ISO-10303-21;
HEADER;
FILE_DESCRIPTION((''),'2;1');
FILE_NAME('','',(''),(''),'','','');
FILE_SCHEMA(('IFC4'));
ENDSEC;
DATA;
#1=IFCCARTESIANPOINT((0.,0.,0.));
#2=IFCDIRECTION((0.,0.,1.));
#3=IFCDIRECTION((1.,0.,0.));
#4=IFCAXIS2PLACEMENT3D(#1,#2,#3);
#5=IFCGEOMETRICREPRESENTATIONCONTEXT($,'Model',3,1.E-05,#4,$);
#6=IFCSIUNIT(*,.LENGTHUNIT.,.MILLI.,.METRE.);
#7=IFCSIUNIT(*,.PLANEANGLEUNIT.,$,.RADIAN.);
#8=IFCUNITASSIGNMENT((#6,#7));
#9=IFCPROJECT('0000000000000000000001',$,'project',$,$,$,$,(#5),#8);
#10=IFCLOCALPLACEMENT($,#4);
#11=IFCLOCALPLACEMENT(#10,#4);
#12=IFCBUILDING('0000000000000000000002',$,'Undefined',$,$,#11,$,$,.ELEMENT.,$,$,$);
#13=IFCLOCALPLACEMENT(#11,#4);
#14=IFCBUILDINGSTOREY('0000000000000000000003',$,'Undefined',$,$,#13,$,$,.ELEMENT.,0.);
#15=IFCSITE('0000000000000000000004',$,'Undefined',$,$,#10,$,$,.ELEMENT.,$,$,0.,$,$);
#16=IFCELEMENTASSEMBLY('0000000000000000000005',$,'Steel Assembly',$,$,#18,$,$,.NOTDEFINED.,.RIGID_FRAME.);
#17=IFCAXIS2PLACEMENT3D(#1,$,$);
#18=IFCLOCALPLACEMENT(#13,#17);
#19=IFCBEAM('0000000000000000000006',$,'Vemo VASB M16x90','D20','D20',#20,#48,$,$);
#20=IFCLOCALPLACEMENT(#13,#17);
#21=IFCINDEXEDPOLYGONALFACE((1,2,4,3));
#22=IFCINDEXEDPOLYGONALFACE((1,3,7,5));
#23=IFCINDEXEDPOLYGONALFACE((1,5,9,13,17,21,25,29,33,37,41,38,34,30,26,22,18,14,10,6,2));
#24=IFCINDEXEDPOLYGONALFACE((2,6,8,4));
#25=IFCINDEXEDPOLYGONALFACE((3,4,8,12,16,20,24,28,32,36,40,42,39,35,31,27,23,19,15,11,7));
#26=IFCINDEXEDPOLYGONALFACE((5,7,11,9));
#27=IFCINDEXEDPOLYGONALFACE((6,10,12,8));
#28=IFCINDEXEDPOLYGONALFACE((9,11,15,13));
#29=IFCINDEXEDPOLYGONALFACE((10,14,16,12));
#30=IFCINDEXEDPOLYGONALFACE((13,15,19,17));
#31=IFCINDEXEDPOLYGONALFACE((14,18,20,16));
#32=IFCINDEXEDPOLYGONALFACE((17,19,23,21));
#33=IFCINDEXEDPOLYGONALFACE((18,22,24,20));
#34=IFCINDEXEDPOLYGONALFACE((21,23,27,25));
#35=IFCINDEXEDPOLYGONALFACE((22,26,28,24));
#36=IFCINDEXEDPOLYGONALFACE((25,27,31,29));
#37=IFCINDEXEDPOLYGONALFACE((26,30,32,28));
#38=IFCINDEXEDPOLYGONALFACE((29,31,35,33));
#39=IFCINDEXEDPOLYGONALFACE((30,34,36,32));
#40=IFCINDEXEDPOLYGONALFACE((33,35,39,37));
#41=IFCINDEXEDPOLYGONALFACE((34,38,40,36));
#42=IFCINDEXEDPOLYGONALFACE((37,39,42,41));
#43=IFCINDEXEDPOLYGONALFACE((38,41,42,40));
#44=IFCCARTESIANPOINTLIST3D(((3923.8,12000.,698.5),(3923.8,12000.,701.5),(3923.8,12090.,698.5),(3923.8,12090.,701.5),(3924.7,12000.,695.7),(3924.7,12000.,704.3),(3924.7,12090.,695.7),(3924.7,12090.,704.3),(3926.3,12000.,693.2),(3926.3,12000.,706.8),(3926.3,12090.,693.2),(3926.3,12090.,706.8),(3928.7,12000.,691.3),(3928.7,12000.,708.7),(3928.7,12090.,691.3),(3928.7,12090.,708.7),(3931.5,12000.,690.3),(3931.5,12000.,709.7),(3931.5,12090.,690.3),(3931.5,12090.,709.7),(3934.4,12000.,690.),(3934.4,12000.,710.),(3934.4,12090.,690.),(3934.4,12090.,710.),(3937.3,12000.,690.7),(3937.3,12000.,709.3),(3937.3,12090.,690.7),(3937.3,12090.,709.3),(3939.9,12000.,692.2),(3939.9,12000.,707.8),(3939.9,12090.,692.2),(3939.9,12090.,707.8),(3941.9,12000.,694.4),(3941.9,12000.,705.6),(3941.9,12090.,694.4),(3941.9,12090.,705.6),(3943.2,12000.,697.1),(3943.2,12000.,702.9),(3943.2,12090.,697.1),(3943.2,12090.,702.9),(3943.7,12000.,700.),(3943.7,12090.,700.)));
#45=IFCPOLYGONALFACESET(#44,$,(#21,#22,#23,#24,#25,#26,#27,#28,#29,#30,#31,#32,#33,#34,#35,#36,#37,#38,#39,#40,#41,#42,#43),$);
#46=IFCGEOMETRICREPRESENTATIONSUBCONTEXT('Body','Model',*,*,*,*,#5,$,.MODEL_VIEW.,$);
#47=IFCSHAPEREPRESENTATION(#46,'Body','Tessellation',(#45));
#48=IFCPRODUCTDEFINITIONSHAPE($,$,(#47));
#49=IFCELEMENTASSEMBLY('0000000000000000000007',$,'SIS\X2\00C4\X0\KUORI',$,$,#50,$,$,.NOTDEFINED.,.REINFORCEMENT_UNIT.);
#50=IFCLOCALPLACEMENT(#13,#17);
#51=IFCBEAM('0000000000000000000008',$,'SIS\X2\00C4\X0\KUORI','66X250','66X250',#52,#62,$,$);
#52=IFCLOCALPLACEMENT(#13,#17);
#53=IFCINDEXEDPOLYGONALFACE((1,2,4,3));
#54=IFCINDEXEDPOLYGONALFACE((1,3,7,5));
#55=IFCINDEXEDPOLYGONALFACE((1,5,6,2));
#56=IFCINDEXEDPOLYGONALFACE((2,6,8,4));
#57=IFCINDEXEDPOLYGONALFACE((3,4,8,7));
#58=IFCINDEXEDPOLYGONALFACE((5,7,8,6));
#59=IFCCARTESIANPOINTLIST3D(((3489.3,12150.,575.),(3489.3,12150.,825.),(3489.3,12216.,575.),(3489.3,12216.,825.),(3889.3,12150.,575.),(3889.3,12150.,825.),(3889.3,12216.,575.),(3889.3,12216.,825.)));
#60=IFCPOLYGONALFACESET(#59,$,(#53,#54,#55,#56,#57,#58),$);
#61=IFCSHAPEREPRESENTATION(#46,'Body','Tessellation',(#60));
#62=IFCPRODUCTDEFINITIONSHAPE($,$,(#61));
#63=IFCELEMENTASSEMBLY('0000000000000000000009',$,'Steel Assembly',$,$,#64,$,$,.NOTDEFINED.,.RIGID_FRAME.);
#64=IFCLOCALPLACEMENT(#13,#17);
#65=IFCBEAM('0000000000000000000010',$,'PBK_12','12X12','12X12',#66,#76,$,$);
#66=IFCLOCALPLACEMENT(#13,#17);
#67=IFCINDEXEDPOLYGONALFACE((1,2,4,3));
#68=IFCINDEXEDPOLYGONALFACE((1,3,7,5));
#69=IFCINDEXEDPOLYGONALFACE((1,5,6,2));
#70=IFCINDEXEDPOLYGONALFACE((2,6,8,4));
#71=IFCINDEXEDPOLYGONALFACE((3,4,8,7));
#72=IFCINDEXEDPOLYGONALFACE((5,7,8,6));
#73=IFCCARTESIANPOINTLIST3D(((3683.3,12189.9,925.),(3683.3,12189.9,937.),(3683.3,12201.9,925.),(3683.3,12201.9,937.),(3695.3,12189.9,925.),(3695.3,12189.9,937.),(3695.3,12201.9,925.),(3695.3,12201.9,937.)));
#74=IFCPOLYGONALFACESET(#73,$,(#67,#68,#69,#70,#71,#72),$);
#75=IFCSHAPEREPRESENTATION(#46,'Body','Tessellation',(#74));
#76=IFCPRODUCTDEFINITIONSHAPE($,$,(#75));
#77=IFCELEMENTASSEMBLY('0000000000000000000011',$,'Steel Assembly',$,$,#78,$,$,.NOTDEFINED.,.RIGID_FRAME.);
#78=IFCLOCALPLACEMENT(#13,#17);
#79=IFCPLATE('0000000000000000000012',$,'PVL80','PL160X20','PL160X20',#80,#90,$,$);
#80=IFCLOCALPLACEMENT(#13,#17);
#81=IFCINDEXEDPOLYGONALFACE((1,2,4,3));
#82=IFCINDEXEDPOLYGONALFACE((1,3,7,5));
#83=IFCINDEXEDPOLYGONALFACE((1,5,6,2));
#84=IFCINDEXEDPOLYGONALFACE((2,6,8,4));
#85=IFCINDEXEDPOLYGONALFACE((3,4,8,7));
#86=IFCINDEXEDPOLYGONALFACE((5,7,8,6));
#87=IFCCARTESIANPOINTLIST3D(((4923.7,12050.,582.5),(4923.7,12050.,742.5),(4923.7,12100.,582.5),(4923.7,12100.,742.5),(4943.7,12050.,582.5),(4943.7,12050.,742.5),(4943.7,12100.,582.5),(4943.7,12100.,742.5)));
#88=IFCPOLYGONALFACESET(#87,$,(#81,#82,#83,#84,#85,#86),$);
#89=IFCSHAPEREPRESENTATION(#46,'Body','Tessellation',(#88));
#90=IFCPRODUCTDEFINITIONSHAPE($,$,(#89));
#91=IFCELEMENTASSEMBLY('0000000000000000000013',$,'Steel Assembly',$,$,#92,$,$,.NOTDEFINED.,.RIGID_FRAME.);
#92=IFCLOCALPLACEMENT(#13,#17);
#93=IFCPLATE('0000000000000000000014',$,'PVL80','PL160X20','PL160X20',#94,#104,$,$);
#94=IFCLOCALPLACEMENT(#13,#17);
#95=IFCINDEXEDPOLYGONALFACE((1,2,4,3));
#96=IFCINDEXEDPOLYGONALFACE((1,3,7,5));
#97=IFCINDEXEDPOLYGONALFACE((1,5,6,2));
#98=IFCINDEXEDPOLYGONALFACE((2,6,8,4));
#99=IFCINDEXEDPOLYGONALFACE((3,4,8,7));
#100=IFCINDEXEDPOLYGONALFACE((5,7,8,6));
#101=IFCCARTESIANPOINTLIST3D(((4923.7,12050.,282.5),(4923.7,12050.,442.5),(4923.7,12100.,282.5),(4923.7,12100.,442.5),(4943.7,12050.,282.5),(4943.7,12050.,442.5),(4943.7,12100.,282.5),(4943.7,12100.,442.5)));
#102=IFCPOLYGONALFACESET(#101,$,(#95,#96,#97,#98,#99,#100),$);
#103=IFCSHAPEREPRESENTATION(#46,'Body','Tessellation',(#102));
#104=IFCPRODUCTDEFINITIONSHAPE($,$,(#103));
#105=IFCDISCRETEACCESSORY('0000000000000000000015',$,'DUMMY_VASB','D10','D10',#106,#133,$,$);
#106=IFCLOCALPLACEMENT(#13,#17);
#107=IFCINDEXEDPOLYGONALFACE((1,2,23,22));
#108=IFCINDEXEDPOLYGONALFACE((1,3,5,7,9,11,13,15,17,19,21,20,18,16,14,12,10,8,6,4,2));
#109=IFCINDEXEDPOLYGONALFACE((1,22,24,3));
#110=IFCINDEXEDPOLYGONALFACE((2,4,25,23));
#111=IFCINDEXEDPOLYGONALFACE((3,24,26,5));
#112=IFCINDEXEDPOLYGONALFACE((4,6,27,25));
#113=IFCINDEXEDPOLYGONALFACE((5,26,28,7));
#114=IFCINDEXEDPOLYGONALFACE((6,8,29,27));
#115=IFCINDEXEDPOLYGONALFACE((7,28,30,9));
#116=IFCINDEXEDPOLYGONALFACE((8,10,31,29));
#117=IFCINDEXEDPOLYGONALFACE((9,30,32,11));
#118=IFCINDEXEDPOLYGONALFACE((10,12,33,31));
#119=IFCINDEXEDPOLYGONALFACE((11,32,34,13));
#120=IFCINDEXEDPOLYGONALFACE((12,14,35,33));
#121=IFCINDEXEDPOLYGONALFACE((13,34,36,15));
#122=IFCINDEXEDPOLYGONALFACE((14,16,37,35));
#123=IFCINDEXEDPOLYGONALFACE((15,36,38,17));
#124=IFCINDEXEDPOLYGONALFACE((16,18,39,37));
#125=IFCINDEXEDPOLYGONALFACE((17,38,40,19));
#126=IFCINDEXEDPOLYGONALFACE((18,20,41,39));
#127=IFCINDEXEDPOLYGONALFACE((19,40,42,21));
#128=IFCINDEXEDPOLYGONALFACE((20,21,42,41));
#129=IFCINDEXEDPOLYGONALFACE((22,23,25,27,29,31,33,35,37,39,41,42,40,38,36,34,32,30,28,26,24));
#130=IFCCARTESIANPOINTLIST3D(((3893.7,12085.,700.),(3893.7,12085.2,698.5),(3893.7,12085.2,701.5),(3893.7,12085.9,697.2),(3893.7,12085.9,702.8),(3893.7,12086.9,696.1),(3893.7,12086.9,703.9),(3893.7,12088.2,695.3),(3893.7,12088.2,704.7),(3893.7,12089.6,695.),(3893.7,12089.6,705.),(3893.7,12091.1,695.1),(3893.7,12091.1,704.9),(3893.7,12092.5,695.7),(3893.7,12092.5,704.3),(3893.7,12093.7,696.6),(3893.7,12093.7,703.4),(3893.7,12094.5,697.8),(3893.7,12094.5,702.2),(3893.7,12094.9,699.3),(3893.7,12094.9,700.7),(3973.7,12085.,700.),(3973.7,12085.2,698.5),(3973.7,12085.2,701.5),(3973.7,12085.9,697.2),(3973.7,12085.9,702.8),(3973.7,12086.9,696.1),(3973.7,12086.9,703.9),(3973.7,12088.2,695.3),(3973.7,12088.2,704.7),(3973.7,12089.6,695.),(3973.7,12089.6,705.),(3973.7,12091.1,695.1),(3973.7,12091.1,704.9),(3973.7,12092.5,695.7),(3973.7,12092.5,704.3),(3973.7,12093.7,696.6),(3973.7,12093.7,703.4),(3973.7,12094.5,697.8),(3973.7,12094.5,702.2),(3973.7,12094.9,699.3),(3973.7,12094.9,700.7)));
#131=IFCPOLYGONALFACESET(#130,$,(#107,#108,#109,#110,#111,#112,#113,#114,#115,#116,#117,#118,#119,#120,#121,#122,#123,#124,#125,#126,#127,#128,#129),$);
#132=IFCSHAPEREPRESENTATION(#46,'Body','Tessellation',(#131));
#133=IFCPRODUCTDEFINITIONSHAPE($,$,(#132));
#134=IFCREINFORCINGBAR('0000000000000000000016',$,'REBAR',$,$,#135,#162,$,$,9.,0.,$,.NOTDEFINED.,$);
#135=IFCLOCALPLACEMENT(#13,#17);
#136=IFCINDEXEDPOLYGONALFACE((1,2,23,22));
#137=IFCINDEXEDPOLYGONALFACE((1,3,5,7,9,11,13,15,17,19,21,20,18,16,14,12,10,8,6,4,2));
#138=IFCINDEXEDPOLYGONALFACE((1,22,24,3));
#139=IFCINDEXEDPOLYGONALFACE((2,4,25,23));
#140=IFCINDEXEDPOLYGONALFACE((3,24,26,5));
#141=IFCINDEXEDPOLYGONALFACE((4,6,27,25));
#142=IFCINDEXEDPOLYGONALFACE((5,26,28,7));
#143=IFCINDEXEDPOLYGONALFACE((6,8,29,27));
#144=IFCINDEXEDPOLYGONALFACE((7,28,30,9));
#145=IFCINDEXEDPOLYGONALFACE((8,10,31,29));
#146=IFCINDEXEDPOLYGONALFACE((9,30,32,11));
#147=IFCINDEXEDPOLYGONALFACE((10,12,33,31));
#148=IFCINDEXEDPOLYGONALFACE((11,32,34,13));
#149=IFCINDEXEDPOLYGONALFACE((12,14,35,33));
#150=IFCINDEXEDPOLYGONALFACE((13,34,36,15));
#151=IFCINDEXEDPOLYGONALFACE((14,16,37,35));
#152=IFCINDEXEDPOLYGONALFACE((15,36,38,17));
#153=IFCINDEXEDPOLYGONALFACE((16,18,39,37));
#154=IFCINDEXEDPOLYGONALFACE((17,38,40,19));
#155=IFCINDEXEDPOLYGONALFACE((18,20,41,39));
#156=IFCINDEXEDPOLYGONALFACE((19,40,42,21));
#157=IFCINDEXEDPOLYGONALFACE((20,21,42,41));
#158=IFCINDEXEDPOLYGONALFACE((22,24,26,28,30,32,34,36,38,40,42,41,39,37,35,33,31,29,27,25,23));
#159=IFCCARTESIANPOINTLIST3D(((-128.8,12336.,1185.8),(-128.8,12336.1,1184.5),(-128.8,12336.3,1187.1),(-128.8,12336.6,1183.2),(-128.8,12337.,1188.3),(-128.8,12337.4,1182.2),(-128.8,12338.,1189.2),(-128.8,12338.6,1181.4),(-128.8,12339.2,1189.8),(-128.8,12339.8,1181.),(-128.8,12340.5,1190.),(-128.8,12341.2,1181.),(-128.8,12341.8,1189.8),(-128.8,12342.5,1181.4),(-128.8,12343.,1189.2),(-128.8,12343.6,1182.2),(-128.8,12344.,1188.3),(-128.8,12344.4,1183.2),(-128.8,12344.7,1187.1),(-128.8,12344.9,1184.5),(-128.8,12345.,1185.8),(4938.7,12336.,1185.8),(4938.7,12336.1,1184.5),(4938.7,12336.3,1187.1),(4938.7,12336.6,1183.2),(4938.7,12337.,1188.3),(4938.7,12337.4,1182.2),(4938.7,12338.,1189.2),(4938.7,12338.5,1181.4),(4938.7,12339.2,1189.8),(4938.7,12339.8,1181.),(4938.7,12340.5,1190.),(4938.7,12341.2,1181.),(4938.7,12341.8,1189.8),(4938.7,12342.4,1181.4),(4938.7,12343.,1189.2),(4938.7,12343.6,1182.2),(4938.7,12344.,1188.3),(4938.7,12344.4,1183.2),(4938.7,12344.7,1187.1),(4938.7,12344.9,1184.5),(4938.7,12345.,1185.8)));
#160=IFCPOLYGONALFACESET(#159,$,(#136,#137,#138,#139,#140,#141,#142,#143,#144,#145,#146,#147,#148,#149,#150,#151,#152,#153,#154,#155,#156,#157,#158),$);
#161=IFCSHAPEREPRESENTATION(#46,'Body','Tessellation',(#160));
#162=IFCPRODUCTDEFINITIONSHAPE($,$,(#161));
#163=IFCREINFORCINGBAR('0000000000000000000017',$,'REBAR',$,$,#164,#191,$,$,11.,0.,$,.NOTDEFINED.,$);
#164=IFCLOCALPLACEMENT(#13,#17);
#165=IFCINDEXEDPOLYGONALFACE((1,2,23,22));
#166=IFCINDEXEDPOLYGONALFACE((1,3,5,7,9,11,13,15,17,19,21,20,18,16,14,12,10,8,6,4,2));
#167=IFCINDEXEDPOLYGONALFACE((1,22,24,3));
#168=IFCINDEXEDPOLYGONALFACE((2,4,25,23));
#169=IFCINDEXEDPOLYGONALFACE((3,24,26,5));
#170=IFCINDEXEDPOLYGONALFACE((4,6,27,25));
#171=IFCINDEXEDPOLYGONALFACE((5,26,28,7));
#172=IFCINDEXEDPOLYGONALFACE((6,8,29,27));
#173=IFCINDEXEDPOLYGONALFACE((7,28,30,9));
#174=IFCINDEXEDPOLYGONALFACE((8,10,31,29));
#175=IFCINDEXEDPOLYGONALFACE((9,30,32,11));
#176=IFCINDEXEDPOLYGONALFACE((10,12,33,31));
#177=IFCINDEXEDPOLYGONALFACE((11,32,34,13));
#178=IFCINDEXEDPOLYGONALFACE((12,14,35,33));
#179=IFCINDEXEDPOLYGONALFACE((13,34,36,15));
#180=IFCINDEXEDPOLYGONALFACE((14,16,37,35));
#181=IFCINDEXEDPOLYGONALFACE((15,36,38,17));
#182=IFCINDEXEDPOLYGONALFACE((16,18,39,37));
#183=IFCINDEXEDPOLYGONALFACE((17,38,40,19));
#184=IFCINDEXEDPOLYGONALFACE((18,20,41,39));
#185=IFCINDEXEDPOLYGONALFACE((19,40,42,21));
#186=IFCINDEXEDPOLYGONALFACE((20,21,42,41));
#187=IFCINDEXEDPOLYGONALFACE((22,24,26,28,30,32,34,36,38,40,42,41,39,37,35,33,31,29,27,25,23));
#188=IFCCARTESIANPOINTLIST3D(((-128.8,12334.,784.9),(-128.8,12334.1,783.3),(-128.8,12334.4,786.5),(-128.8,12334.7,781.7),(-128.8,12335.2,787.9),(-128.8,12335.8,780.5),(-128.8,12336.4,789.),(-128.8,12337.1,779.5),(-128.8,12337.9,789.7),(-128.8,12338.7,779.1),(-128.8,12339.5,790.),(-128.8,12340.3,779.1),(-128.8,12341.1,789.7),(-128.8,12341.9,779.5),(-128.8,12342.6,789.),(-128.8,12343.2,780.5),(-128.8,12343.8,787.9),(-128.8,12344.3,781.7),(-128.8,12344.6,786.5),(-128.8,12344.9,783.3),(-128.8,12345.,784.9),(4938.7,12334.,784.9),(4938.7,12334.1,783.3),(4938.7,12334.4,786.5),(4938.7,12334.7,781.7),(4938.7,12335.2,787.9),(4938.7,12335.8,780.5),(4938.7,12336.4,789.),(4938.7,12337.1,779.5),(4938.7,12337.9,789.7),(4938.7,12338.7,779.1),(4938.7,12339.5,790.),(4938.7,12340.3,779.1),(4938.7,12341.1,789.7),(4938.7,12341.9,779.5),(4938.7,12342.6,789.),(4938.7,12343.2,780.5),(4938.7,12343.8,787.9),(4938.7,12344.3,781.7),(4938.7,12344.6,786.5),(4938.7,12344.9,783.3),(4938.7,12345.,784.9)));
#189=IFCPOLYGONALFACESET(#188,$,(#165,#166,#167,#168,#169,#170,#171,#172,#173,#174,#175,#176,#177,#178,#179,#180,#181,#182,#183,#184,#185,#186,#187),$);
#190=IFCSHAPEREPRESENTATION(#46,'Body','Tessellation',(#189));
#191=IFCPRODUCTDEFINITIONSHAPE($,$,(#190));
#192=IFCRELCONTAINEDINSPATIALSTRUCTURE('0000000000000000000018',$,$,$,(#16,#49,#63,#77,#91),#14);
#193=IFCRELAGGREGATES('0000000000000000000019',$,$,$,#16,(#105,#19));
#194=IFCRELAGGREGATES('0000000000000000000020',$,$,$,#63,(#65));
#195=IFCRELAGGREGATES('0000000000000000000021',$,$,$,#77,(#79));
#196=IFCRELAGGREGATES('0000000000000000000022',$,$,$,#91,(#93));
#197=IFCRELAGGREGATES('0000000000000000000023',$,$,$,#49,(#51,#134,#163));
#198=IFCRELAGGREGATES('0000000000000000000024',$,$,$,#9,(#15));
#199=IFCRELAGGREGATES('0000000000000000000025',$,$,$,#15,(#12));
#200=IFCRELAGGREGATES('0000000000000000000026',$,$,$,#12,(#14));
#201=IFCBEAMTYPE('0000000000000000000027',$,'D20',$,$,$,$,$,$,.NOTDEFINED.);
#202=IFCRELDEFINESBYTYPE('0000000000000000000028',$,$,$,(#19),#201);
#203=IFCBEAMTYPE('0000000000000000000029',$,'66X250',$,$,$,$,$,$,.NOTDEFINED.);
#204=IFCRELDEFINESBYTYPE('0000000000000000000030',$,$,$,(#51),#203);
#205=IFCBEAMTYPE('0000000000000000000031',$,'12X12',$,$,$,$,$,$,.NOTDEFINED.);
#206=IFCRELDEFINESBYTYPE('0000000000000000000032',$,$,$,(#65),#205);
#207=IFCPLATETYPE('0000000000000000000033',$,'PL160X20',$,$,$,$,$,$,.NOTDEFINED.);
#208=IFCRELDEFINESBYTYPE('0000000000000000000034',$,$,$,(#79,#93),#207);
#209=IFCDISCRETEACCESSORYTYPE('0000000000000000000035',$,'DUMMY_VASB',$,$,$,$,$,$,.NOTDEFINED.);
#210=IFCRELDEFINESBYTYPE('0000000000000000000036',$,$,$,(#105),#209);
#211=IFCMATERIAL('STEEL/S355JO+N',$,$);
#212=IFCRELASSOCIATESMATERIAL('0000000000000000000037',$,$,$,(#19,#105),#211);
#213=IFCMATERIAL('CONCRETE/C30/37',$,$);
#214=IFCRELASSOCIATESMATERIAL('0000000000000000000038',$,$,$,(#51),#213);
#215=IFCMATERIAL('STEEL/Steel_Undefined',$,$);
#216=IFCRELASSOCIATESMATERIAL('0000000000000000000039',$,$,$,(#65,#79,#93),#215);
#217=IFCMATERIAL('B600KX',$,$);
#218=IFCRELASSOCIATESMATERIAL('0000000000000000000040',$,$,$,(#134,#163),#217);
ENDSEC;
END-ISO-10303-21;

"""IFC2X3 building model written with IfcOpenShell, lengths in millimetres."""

from ifc_helpers import new_model, entity, si_unit, frame, origin_with_axes, origin_2d_with_axis, place, context, subcontext, project, spatial, polyline, rectangle, circle, outline, extrude, source, transform, mapped, material, type_object, element, aggregate, save


model = new_model("IFC2X3")

# Units and contexts
model_context = context("Model", 3, precision=1e-05, world=origin_with_axes())
body_context = subcontext(model_context, "Body", "Model", "MODEL_VIEW")
ifc_project = project(units=[si_unit("LENGTHUNIT", "METRE", prefix="MILLI"), si_unit("PLANEANGLEUNIT", "RADIAN")], contexts=[model_context])

# Site, building, storey
site_placement = place(None, origin_with_axes())
site = spatial("IfcSite", under=ifc_project, at=site_placement, Name="Undefined", CompositionType="ELEMENT", RefElevation=0.0)
building_placement = place(site_placement, origin_with_axes())
building = spatial("IfcBuilding", under=site, at=building_placement, Name="Undefined", CompositionType="ELEMENT")
storey_placement = place(building_placement, origin_with_axes())
storey = spatial("IfcBuildingStorey", under=building, at=storey_placement, Name="Undefined", CompositionType="ELEMENT", Elevation=0.0)

# Element assemblies, beams
assembly_1_placement = place(storey_placement, origin_with_axes())
assembly_1 = element("IfcElementAssembly", 1, at=assembly_1_placement, inside=storey, Name="Steel Assembly", AssemblyPlace="NOTDEFINED", PredefinedType="RIGID_FRAME")
ifc_material_1 = material(Name="STEEL/S355JO+N")
beam_type_1 = type_object("IfcBeamType", Name="D20", PredefinedType="NOTDEFINED")
beam_1_placement = place(assembly_1_placement, frame((3933.7, 12000.0, 700.0), z_axis=(0.0, 0.0, 1.0), x_axis=(0.0, 1.0, 0.0)))
beam_1 = element("IfcBeam", 2, at=beam_1_placement, type_object=beam_type_1, material=ifc_material_1, Name="Vemo VASB M16x90", Description="D20", ObjectType="D20", context=body_context, shape_type="SweptSolid", body=[
    extrude(circle(Radius=10.0, at=origin_2d_with_axis()), frame((90.0, 0.0, 0.0), z_axis=(-1.0, 0.0, 0.0), x_axis=(0.0, -1.0, 0.0)), (0.0, 0.0, 1.0), 90.0),
])
assembly_2_placement = place(storey_placement, origin_with_axes())
assembly_2 = element("IfcElementAssembly", 3, at=assembly_2_placement, inside=storey, Name="SISÄKUORI", AssemblyPlace="NOTDEFINED", PredefinedType="REINFORCEMENT_UNIT")
ifc_material_2 = material(Name="CONCRETE/C30/37")
beam_type_2 = type_object("IfcBeamType", Name="66X250", PredefinedType="NOTDEFINED")
beam_2_placement = place(assembly_2_placement, frame((3489.3, 12183.0, 700.0), z_axis=(0.0, -1.0, 0.0), x_axis=(1.0, 0.0, 0.0)))
beam_2 = element("IfcBeam", 4, at=beam_2_placement, type_object=beam_type_2, material=ifc_material_2, Name="SISÄKUORI", Description="66X250", ObjectType="66X250", context=body_context, shape_type="SweptSolid", body=[
    extrude(rectangle(XDim=250.0, YDim=66.0, at=origin_2d_with_axis()), frame((400.0, 0.0, 0.0), z_axis=(-1.0, 0.0, 0.0), x_axis=(0.0, -1.0, 0.0)), (0.0, 0.0, 1.0), 400.0),
])
assembly_3_placement = place(storey_placement, origin_with_axes())
assembly_3 = element("IfcElementAssembly", 5, at=assembly_3_placement, inside=storey, Name="Steel Assembly", AssemblyPlace="NOTDEFINED", PredefinedType="RIGID_FRAME")
ifc_material_3 = material(Name="STEEL/Steel_Undefined")
beam_type_3 = type_object("IfcBeamType", Name="12X12", PredefinedType="NOTDEFINED")
beam_3_placement = place(assembly_3_placement, frame((3695.3, 12195.9, 931.0), z_axis=(0.0, 0.0, 1.0), x_axis=(-1.0, 0.0, 0.0)))
beam_3 = element("IfcBeam", 6, at=beam_3_placement, type_object=beam_type_3, material=ifc_material_3, Name="PBK_12", Description="12X12", ObjectType="12X12", context=body_context, shape_type="SweptSolid", body=[
    extrude(rectangle(XDim=12.0, YDim=12.0, at=origin_2d_with_axis()), frame((12.0, 0.0, 0.0), z_axis=(-1.0, 0.0, 0.0), x_axis=(0.0, -1.0, 0.0)), (0.0, 0.0, 1.0), 12.0),
])

# Element assemblies, plates
assembly_4_placement = place(storey_placement, origin_with_axes())
assembly_4 = element("IfcElementAssembly", 7, at=assembly_4_placement, inside=storey, Name="Steel Assembly", AssemblyPlace="NOTDEFINED", PredefinedType="RIGID_FRAME")
plate_type = type_object("IfcPlateType", Name="PL160X20", PredefinedType="NOTDEFINED")
plate_1_placement = place(assembly_4_placement, frame((4943.7, 12100.0, 662.5), z_axis=(0.0, 0.0, -1.0), x_axis=(0.0, -1.0, 0.0)))
plate_1 = element("IfcPlate", 8, at=plate_1_placement, type_object=plate_type, material=ifc_material_3, Name="PVL80", Description="PL160X20", ObjectType="PL160X20", context=body_context, shape_type="SweptSolid", body=[
    extrude(outline(polyline([(0.0, 0.0), (50.0, 0.0), (50.0, 20.0), (0.0, 20.0), (0.0, 0.0)])), frame((0.0, 0.0, -80.0), z_axis=(0.0, 0.0, 1.0), x_axis=(1.0, 0.0, 0.0)), (0.0, 0.0, 1.0), 160.0),
])
assembly_5_placement = place(storey_placement, origin_with_axes())
assembly_5 = element("IfcElementAssembly", 9, at=assembly_5_placement, inside=storey, Name="Steel Assembly", AssemblyPlace="NOTDEFINED", PredefinedType="RIGID_FRAME")
plate_2_placement = place(assembly_5_placement, frame((4943.7, 12100.0, 362.5), z_axis=(0.0, 0.0, -1.0), x_axis=(0.0, -1.0, 0.0)))
plate_2 = element("IfcPlate", 10, at=plate_2_placement, type_object=plate_type, material=ifc_material_3, Name="PVL80", Description="PL160X20", ObjectType="PL160X20", context=body_context, shape_type="SweptSolid", body=[
    extrude(outline(polyline([(0.0, 0.0), (50.0, 0.0), (50.0, 20.0), (0.0, 20.0), (0.0, 0.0)])), frame((0.0, 0.0, -80.0), z_axis=(0.0, 0.0, 1.0), x_axis=(1.0, 0.0, 0.0)), (0.0, 0.0, 1.0), 160.0),
])

# Discrete accessory
discrete_accessory_type = type_object("IfcDiscreteAccessoryType", Name="DUMMY_VASB")
discrete_accessory_placement = place(assembly_1_placement, frame((3893.7, 12090.0, 700.0), z_axis=(0.0, 0.0, 1.0), x_axis=(1.0, 0.0, 0.0)))
discrete_accessory = element("IfcDiscreteAccessory", 11, at=discrete_accessory_placement, type_object=discrete_accessory_type, material=ifc_material_1, Name="DUMMY_VASB", Description="D10", ObjectType="D10", context=body_context, shape_type="SweptSolid", body=[
    extrude(circle(Radius=5.0, at=origin_2d_with_axis()), frame((80.0, 0.0, 0.0), z_axis=(-1.0, 0.0, 0.0), x_axis=(0.0, -1.0, 0.0)), (0.0, 0.0, 1.0), 80.0),
])
aggregate(assembly_1, [discrete_accessory, beam_1])

# Reinforcing bars
aggregate(assembly_3, [beam_3])
aggregate(assembly_4, [plate_1])
aggregate(assembly_5, [plate_2])
ifc_material_4 = material(Name="B600KX")
shared_shape_1 = source(origin_with_axes(), body_context, "Body", "AdvancedSweptSolid", [
    entity("IfcSweptDiskSolid", entity("IfcTrimmedCurve", entity("IfcLine", entity("IfcCartesianPoint", [0.0, 0.0, 0.0]), entity("IfcVector", entity("IfcDirection", [1.0, 0.0, 0.0]), 1.0)), [entity("IfcParameterValue", 0.0)], [entity("IfcParameterValue", 5067.479996)], True, "PARAMETER"), 4.5, None, 0.0, 5067.5),
])
reinforcing_bar_1_placement = place(assembly_2_placement, frame((4938.7, 12340.5, 1185.5), z_axis=(0.0, 0.0, 1.0), x_axis=(-1.0, 0.000003, 0.0)))
reinforcing_bar_1 = element("IfcReinforcingBar", 12, at=reinforcing_bar_1_placement, material=ifc_material_4, Name="REBAR", BarRole="NOTDEFINED", CrossSectionArea=0.0, NominalDiameter=9.0, context=body_context, shape_type="MappedRepresentation", body=[
    mapped(shared_shape_1, transform((0.0, 0.0, 0.0))),
])
shared_shape_2 = source(origin_with_axes(), body_context, "Body", "AdvancedSweptSolid", [
    entity("IfcSweptDiskSolid", entity("IfcTrimmedCurve", entity("IfcLine", entity("IfcCartesianPoint", [0.0, 0.0, 0.0]), entity("IfcVector", entity("IfcDirection", [1.0, 0.0, 0.0]), 1.0)), [entity("IfcParameterValue", 0.0)], [entity("IfcParameterValue", 5067.479996)], True, "PARAMETER"), 5.5, None, 0.0, 5067.5),
])
reinforcing_bar_2_placement = place(assembly_2_placement, frame((4938.7, 12339.5, 784.5), z_axis=(0.0, 0.0, 1.0), x_axis=(-1.0, 0.000003, 0.0)))
reinforcing_bar_2 = element("IfcReinforcingBar", 13, at=reinforcing_bar_2_placement, material=ifc_material_4, Name="REBAR", BarRole="NOTDEFINED", CrossSectionArea=0.0, NominalDiameter=11.0, context=body_context, shape_type="MappedRepresentation", body=[
    mapped(shared_shape_2, transform((0.0, 0.0, 0.0))),
])
aggregate(assembly_2, [beam_2, reinforcing_bar_1, reinforcing_bar_2])

save(model, "model.ifc")
